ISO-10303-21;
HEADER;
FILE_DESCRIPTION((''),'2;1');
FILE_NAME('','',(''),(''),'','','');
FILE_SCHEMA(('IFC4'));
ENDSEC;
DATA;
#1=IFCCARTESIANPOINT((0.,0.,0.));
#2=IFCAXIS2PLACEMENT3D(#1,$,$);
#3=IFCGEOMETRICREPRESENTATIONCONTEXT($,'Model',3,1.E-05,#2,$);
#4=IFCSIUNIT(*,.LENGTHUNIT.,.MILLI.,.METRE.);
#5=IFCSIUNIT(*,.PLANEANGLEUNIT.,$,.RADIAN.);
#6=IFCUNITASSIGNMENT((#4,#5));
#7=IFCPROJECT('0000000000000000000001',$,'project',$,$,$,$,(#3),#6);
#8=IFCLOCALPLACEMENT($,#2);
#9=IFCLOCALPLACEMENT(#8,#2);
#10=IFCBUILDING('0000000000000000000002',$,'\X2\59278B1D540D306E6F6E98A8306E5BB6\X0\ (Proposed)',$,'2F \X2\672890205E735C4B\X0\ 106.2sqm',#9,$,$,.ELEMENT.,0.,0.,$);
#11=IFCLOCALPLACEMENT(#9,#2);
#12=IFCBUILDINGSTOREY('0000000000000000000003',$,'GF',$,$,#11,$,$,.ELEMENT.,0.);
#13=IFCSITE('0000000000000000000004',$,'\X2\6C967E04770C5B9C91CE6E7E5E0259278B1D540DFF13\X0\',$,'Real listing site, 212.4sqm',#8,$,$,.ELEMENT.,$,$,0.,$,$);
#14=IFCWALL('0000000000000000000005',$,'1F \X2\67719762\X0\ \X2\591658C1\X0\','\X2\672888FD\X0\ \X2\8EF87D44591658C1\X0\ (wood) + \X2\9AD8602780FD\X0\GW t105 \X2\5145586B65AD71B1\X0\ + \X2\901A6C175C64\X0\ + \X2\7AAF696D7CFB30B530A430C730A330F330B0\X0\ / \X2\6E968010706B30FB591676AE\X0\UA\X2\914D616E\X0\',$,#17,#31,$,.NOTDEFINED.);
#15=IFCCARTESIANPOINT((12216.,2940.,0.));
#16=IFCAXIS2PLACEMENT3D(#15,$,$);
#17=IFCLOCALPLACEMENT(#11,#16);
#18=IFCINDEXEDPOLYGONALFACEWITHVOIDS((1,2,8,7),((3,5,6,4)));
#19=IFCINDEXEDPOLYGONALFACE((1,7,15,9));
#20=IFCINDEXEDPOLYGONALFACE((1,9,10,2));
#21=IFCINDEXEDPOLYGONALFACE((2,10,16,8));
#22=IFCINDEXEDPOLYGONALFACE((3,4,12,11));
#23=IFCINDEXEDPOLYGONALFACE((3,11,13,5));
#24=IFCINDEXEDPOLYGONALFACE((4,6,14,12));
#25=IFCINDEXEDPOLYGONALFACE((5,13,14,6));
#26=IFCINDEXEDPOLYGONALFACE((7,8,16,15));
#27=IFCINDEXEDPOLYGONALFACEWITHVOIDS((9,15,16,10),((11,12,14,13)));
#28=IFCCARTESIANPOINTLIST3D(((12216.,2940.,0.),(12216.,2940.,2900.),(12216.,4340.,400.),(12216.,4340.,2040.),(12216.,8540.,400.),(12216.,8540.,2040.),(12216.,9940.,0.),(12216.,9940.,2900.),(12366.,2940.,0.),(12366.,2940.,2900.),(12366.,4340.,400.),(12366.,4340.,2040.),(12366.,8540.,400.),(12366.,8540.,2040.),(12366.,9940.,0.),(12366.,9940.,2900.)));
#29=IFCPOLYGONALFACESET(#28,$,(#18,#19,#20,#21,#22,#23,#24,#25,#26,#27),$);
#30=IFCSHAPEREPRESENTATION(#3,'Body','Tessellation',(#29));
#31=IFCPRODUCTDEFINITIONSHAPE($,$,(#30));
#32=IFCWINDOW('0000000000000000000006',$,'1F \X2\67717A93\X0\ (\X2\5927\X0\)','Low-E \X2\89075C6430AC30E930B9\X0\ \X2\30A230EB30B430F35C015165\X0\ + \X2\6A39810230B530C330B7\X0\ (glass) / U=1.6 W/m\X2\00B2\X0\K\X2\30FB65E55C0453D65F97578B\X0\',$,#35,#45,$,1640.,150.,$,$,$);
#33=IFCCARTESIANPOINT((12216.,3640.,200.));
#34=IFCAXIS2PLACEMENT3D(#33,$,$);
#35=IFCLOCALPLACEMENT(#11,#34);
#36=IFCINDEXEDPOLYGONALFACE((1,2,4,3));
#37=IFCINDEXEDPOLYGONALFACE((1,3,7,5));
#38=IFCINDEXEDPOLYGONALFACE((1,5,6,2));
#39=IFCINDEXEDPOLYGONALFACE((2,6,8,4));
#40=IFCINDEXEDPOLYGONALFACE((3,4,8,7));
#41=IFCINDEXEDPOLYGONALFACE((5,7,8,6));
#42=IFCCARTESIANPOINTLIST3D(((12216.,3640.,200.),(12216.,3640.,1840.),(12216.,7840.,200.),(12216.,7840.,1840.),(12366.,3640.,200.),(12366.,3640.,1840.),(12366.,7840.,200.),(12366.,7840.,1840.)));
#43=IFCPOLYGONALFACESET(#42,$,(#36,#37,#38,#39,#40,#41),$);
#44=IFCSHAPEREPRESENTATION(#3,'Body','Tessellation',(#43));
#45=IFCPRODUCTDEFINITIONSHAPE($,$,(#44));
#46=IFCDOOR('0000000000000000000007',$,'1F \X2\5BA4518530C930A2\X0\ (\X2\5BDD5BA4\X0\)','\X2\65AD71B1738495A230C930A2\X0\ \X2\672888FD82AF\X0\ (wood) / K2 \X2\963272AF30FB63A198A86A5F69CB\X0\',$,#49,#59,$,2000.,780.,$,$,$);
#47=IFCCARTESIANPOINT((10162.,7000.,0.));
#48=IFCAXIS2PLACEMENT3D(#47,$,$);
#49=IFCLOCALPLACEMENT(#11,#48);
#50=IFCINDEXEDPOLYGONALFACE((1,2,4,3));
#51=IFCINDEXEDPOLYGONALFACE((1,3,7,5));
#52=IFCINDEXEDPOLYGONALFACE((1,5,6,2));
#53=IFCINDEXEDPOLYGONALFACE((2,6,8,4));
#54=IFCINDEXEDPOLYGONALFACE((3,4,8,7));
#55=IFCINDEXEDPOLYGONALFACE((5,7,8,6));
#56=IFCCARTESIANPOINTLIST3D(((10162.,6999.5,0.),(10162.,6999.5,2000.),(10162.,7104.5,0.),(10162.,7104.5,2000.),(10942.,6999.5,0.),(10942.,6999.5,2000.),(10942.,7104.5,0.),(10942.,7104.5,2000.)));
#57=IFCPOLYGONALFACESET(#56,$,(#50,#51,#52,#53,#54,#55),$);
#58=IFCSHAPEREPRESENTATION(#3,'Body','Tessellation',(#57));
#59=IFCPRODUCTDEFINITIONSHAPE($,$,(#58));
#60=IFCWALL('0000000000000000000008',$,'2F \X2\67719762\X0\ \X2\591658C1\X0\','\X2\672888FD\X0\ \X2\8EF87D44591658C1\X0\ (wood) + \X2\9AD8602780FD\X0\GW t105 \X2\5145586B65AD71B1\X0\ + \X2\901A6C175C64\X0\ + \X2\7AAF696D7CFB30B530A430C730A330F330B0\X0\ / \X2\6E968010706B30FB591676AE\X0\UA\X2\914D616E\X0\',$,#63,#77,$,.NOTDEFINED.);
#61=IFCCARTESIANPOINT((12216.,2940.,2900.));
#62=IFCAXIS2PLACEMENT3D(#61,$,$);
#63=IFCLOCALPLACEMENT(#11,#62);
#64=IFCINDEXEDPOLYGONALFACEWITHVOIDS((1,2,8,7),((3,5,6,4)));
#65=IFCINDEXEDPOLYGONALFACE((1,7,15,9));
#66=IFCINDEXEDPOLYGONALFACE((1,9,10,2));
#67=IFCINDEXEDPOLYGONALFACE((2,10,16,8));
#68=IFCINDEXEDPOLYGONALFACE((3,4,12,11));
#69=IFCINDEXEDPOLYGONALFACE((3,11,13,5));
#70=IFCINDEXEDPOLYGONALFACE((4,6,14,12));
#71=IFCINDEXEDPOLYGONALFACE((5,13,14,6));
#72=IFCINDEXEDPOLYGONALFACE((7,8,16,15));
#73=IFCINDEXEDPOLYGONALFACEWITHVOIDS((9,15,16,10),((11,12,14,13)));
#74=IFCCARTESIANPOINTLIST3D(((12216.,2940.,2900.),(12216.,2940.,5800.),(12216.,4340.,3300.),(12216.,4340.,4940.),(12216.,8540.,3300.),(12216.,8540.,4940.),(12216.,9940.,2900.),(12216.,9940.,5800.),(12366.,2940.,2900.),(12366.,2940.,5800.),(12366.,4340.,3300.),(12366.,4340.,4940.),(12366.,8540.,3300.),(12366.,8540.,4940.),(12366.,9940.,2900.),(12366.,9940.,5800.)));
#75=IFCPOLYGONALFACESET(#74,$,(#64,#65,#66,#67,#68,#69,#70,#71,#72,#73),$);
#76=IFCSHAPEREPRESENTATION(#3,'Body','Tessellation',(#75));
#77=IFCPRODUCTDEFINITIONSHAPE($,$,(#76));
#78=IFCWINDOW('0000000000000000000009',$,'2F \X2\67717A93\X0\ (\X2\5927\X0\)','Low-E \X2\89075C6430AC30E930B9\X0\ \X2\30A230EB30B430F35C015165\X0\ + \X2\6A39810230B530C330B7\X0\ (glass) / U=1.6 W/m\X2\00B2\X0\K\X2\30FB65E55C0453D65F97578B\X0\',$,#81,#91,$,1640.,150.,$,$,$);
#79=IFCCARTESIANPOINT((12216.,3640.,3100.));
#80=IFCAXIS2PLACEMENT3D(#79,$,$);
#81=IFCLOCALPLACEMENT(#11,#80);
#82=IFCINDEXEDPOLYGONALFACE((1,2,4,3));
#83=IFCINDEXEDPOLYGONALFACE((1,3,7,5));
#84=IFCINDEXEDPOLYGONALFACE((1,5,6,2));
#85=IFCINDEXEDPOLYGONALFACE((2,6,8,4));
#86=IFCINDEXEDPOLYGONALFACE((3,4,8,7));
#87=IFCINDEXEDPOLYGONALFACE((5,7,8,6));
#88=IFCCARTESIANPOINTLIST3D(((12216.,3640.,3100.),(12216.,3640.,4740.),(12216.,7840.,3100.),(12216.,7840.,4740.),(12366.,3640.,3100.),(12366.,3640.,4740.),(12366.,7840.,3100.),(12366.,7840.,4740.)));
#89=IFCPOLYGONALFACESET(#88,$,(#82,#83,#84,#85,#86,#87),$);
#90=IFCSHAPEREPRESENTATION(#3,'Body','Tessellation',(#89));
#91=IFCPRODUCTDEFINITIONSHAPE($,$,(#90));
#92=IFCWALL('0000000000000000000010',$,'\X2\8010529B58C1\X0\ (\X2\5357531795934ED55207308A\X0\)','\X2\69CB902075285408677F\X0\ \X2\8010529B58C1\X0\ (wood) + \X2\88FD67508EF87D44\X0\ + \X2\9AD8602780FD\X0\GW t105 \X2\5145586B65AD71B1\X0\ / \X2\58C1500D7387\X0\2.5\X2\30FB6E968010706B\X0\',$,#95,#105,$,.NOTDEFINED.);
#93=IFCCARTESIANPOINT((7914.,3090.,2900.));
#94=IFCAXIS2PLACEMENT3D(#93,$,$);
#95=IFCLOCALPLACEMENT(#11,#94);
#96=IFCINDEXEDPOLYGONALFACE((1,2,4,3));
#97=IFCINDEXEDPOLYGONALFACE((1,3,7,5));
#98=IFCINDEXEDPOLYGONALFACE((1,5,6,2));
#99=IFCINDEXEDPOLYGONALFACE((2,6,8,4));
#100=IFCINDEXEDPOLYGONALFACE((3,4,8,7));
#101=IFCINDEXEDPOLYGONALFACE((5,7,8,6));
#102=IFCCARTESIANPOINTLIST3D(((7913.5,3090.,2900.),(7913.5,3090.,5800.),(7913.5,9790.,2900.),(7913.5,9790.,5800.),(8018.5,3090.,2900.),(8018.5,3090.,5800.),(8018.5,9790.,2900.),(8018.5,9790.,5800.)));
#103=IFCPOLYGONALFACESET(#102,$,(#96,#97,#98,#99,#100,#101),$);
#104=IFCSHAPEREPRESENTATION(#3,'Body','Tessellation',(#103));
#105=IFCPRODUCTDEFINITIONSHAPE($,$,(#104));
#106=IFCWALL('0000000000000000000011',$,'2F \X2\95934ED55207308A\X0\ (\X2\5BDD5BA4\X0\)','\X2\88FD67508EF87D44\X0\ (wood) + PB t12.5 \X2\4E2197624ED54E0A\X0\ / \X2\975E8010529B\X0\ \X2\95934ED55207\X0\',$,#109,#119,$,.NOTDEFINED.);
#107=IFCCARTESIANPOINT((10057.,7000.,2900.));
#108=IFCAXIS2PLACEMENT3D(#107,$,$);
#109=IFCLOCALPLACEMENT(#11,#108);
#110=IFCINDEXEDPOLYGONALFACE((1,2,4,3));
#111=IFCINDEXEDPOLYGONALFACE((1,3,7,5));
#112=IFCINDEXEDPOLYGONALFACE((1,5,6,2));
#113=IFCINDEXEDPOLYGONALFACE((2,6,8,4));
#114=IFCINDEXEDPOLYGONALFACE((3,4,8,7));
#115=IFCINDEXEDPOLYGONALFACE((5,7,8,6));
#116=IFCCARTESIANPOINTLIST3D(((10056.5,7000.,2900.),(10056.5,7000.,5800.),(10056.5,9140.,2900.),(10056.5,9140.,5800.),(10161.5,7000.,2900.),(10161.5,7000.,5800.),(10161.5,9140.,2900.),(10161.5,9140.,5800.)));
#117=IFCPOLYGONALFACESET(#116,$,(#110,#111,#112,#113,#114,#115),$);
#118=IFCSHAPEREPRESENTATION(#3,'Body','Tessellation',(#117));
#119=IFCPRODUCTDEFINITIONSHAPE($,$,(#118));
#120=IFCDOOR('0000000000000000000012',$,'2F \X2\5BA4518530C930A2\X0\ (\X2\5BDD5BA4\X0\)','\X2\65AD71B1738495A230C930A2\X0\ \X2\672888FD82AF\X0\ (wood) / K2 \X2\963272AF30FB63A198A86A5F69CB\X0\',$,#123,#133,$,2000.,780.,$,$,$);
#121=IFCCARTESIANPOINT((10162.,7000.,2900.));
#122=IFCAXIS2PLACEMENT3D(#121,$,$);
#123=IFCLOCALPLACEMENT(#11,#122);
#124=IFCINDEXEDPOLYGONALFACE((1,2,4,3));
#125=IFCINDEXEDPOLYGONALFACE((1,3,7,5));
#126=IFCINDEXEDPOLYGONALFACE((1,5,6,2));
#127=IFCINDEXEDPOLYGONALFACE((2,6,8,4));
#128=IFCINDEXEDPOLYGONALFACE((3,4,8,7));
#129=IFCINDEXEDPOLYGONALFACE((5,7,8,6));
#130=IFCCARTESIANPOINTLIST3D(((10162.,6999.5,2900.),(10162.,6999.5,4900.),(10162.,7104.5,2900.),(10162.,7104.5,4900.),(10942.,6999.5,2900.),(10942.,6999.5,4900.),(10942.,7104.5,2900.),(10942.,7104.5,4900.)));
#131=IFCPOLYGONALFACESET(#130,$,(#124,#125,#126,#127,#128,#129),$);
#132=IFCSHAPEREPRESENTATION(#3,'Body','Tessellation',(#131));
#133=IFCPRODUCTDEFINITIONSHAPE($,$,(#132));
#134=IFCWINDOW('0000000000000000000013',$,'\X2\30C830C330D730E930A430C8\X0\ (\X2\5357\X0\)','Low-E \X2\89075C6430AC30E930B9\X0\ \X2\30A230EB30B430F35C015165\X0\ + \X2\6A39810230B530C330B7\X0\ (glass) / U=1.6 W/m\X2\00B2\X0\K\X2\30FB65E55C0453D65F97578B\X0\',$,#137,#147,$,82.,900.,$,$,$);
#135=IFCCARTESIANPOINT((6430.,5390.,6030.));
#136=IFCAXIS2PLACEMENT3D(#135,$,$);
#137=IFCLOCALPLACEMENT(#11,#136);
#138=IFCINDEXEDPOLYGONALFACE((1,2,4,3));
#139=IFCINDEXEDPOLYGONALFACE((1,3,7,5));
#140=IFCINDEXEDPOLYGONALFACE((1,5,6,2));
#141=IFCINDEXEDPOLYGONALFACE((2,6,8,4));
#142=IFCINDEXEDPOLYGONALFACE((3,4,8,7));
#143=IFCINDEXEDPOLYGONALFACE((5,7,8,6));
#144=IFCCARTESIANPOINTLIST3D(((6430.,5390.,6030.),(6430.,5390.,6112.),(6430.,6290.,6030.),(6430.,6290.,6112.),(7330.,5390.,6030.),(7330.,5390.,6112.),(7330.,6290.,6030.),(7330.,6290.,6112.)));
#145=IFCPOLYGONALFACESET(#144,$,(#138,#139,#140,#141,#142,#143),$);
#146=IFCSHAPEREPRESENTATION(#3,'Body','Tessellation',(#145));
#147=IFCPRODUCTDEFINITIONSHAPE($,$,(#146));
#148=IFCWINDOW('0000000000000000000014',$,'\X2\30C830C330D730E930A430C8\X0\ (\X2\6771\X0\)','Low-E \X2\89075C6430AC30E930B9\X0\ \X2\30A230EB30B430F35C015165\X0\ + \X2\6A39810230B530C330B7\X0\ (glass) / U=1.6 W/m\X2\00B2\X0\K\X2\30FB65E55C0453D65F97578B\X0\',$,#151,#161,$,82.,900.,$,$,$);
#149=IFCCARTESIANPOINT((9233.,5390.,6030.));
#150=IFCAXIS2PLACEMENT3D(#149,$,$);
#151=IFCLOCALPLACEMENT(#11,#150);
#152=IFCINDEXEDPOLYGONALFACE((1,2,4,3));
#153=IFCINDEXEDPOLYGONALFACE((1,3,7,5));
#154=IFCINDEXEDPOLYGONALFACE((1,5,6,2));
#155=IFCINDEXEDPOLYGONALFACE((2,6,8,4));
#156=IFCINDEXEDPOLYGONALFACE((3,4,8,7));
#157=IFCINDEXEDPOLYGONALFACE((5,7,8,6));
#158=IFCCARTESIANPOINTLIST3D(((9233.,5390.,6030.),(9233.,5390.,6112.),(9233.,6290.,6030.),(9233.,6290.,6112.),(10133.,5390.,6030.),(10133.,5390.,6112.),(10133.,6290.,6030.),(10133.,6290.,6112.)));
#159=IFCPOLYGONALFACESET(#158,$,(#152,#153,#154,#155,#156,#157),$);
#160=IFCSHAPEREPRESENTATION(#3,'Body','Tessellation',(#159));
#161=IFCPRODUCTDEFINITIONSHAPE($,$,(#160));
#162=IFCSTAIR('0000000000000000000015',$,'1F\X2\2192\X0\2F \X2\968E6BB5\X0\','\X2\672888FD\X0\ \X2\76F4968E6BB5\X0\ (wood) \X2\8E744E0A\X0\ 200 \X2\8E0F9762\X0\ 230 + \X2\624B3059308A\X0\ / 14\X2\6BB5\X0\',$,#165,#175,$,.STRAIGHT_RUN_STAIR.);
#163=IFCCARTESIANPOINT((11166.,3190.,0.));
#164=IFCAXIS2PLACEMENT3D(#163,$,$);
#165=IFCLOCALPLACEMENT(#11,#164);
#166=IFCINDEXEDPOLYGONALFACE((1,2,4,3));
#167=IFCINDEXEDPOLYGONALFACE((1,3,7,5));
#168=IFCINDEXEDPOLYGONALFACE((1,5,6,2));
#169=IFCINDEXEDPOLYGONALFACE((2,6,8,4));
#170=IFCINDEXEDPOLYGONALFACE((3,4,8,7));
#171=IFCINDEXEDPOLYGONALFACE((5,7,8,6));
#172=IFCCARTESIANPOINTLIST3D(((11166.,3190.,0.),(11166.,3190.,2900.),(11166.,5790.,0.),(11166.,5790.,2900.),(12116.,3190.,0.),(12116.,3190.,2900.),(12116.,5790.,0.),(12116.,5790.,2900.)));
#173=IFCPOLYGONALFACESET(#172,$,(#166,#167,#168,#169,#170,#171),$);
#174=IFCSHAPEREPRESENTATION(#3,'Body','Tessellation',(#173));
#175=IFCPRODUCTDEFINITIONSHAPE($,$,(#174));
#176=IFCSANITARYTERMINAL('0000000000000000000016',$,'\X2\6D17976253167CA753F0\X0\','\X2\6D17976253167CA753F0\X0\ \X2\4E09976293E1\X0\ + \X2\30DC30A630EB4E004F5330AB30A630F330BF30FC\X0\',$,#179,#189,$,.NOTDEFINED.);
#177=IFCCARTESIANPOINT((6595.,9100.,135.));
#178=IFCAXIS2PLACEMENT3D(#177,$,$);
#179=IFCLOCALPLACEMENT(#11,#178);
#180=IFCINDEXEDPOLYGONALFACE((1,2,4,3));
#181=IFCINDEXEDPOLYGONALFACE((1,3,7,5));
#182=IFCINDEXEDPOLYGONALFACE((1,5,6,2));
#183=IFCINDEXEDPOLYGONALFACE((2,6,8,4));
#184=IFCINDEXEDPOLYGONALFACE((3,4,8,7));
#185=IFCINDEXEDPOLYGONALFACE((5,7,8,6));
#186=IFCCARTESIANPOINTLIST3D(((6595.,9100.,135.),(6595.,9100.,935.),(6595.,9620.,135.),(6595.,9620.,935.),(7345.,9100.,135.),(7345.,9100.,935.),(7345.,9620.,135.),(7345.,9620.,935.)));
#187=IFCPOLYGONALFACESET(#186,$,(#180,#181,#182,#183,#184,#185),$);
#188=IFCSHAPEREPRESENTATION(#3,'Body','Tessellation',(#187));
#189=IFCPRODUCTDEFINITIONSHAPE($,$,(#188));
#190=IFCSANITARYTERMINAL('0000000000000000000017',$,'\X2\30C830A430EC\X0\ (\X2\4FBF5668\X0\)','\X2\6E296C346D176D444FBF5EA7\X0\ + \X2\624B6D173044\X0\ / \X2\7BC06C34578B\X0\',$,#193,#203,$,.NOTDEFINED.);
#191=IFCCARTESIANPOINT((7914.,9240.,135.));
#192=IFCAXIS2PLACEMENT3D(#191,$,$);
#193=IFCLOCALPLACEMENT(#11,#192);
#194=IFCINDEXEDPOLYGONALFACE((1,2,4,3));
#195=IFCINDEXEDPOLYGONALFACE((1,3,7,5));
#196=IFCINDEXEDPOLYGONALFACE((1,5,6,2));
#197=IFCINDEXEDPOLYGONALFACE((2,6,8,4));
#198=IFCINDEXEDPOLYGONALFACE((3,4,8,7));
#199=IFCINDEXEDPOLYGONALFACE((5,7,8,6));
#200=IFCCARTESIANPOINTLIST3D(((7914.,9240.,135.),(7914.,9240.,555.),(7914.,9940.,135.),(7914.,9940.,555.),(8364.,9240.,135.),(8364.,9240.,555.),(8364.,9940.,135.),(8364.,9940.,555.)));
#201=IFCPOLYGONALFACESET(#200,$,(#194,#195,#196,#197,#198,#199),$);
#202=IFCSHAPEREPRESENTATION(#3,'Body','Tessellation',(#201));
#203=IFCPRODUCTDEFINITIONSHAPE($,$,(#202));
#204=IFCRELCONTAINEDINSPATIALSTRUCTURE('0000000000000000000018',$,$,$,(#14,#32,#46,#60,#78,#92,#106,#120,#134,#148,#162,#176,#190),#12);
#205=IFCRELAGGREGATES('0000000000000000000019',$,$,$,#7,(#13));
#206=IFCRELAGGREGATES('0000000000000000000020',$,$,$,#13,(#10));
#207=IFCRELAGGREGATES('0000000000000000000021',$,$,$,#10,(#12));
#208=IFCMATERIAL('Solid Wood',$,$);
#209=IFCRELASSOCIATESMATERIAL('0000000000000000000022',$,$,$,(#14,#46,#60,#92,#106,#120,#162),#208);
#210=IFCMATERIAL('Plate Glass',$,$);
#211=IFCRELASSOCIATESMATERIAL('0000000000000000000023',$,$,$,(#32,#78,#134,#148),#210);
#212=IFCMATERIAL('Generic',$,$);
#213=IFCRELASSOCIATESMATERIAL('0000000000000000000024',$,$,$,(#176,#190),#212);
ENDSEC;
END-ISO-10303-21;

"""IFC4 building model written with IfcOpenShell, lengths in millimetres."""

from ifc_helpers import new_model, si_unit, frame, frame_2d, origin, place, context, project, spatial, rectangle, extrude, material, element, fill, save


model = new_model("IFC4")

# Units and contexts
model_context = context("Model", 3, precision=1e-05, world=origin())
ifc_project = project(units=[si_unit("LENGTHUNIT", "METRE", prefix="MILLI"), si_unit("PLANEANGLEUNIT", "RADIAN")], contexts=[model_context])

# Site, building, storey
site_placement = place(None, origin())
site = spatial("IfcSite", under=ifc_project, at=site_placement, Name="沖縄県宜野湾市大謝名３", ObjectType="Real listing site, 212.4sqm", CompositionType="ELEMENT", RefElevation=0.0)
building_placement = place(site_placement, origin())
building = spatial("IfcBuilding", under=site, at=building_placement, Name="大謝名の潮風の家 (Proposed)", ObjectType="2F 木造平屋 106.2sqm", CompositionType="ELEMENT", ElevationOfRefHeight=0.0, ElevationOfTerrain=0.0)
storey_placement = place(building_placement, origin())
storey = spatial("IfcBuildingStorey", under=building, at=storey_placement, Name="GF", CompositionType="ELEMENT", Elevation=0.0)

# Wall, opening, window
ifc_material_1 = material(Name="Solid Wood")
wall_1_placement = place(storey_placement, frame((12216.0, 2940.0, 0.0)))
wall_1 = element("IfcWall", 1, at=wall_1_placement, inside=storey, material=ifc_material_1, Name="1F 東面 外壁", Description="木製 軸組外壁 (wood) + 高性能GW t105 充填断熱 + 通気層 + 窯業系サイディング / 準耐火・外皮UA配慮", PredefinedType="NOTDEFINED", context=model_context, shape_type="SweptSolid", body=[
    extrude(rectangle(XDim=150.0, YDim=7000.0, at=frame_2d((75.0, 3500.0))), frame((12216.0, 2940.0, 0.0)), (0.0, 0.0, 1.0), 2900.0),
])
opening_1_placement = place(storey_placement, frame((12216.0, 3640.0, 200.0)))
opening_1 = element("IfcOpeningElement", 2, at=opening_1_placement, cuts=wall_1, PredefinedType="NOTDEFINED", context=model_context, shape_type="SweptSolid", body=[
    extrude(rectangle(XDim=150.0, YDim=4200.0, at=frame_2d((75.0, 2100.0))), frame((12216.0, 3640.0, 200.0)), (0.0, 0.0, 1.0), 1640.0),
])
ifc_material_2 = material(Name="Plate Glass")
window_1_placement = place(storey_placement, frame((12216.0, 3640.0, 200.0)))
window_1 = element("IfcWindow", 3, at=window_1_placement, inside=storey, material=ifc_material_2, Name="1F 東窓 (大)", Description="Low-E 複層ガラス アルゴン封入 + 樹脂サッシ (glass) / U=1.6 W/m²K・日射取得型", OverallHeight=1640.0, OverallWidth=150.0, context=model_context, shape_type="SweptSolid", body=[
    extrude(rectangle(XDim=150.0, YDim=4200.0, at=frame_2d((75.0, 2100.0))), frame((12216.0, 3640.0, 200.0)), (0.0, 0.0, 1.0), 1640.0),
])
fill(opening_1, window_1)

# Door
door_1_placement = place(storey_placement, frame((10162.0, 7000.0, 0.0)))
element("IfcDoor", 4, at=door_1_placement, inside=storey, material=ifc_material_1, Name="1F 室内ドア (寝室)", Description="断熱玄関ドア 木製芯 (wood) / K2 防犯・採風機構", OverallHeight=2000.0, OverallWidth=780.0, context=model_context, shape_type="SweptSolid", body=[
    extrude(rectangle(XDim=780.0, YDim=105.0, at=frame_2d((390.0, 52.0))), frame((10162.0, 7000.0, 0.0)), (0.0, 0.0, 1.0), 2000.0),
])

# Wall, opening, window
wall_2_placement = place(storey_placement, frame((12216.0, 2940.0, 2900.0)))
wall_2 = element("IfcWall", 5, at=wall_2_placement, inside=storey, material=ifc_material_1, Name="2F 東面 外壁", Description="木製 軸組外壁 (wood) + 高性能GW t105 充填断熱 + 通気層 + 窯業系サイディング / 準耐火・外皮UA配慮", PredefinedType="NOTDEFINED", context=model_context, shape_type="SweptSolid", body=[
    extrude(rectangle(XDim=150.0, YDim=7000.0, at=frame_2d((75.0, 3500.0))), frame((12216.0, 2940.0, 2900.0)), (0.0, 0.0, 1.0), 2900.0),
])
opening_2_placement = place(storey_placement, frame((12216.0, 3640.0, 3100.0)))
opening_2 = element("IfcOpeningElement", 6, at=opening_2_placement, cuts=wall_2, PredefinedType="NOTDEFINED", context=model_context, shape_type="SweptSolid", body=[
    extrude(rectangle(XDim=150.0, YDim=4200.0, at=frame_2d((75.0, 2100.0))), frame((12216.0, 3640.0, 3100.0)), (0.0, 0.0, 1.0), 1640.0),
])
window_2_placement = place(storey_placement, frame((12216.0, 3640.0, 3100.0)))
window_2 = element("IfcWindow", 7, at=window_2_placement, inside=storey, material=ifc_material_2, Name="2F 東窓 (大)", Description="Low-E 複層ガラス アルゴン封入 + 樹脂サッシ (glass) / U=1.6 W/m²K・日射取得型", OverallHeight=1640.0, OverallWidth=150.0, context=model_context, shape_type="SweptSolid", body=[
    extrude(rectangle(XDim=150.0, YDim=4200.0, at=frame_2d((75.0, 2100.0))), frame((12216.0, 3640.0, 3100.0)), (0.0, 0.0, 1.0), 1640.0),
])
fill(opening_2, window_2)

# Walls
wall_3_placement = place(storey_placement, frame((7914.0, 3090.0, 2900.0)))
element("IfcWall", 8, at=wall_3_placement, inside=storey, material=ifc_material_1, Name="耐力壁 (南北間仕切り)", Description="構造用合板 耐力壁 (wood) + 製材軸組 + 高性能GW t105 充填断熱 / 壁倍率2.5・準耐火", PredefinedType="NOTDEFINED", context=model_context, shape_type="SweptSolid", body=[
    extrude(rectangle(XDim=105.0, YDim=6700.0, at=frame_2d((52.0, 3350.0))), frame((7914.0, 3090.0, 2900.0)), (0.0, 0.0, 1.0), 2900.0),
])
wall_4_placement = place(storey_placement, frame((10057.0, 7000.0, 2900.0)))
element("IfcWall", 9, at=wall_4_placement, inside=storey, material=ifc_material_1, Name="2F 間仕切り (寝室)", Description="製材軸組 (wood) + PB t12.5 両面仕上 / 非耐力 間仕切", PredefinedType="NOTDEFINED", context=model_context, shape_type="SweptSolid", body=[
    extrude(rectangle(XDim=105.0, YDim=2140.0, at=frame_2d((52.0, 1070.0))), frame((10057.0, 7000.0, 2900.0)), (0.0, 0.0, 1.0), 2900.0),
])

# Door
door_2_placement = place(storey_placement, frame((10162.0, 7000.0, 2900.0)))
element("IfcDoor", 10, at=door_2_placement, inside=storey, material=ifc_material_1, Name="2F 室内ドア (寝室)", Description="断熱玄関ドア 木製芯 (wood) / K2 防犯・採風機構", OverallHeight=2000.0, OverallWidth=780.0, context=model_context, shape_type="SweptSolid", body=[
    extrude(rectangle(XDim=780.0, YDim=105.0, at=frame_2d((390.0, 52.0))), frame((10162.0, 7000.0, 2900.0)), (0.0, 0.0, 1.0), 2000.0),
])

# Windows
window_3_placement = place(storey_placement, frame((6430.0, 5390.0, 6030.0)))
element("IfcWindow", 11, at=window_3_placement, inside=storey, material=ifc_material_2, Name="トップライト (南)", Description="Low-E 複層ガラス アルゴン封入 + 樹脂サッシ (glass) / U=1.6 W/m²K・日射取得型", OverallHeight=82.0, OverallWidth=900.0, context=model_context, shape_type="SweptSolid", body=[
    extrude(rectangle(XDim=900.0, YDim=900.0, at=frame_2d((450.0, 450.0))), frame((6430.0, 5390.0, 6030.0)), (0.0, 0.0, 1.0), 82.0),
])
window_4_placement = place(storey_placement, frame((9233.0, 5390.0, 6030.0)))
element("IfcWindow", 12, at=window_4_placement, inside=storey, material=ifc_material_2, Name="トップライト (東)", Description="Low-E 複層ガラス アルゴン封入 + 樹脂サッシ (glass) / U=1.6 W/m²K・日射取得型", OverallHeight=82.0, OverallWidth=900.0, context=model_context, shape_type="SweptSolid", body=[
    extrude(rectangle(XDim=900.0, YDim=900.0, at=frame_2d((450.0, 450.0))), frame((9233.0, 5390.0, 6030.0)), (0.0, 0.0, 1.0), 82.0),
])

# Stair
stair_placement = place(storey_placement, frame((11166.0, 3190.0, 0.0)))
element("IfcStair", 13, at=stair_placement, inside=storey, material=ifc_material_1, Name="1F→2F 階段", Description="木製 直階段 (wood) 蹴上 200 踏面 230 + 手すり / 14段", PredefinedType="STRAIGHT_RUN_STAIR", context=model_context, shape_type="SweptSolid", body=[
    extrude(rectangle(XDim=950.0, YDim=2600.0, at=frame_2d((475.0, 1300.0))), frame((11166.0, 3190.0, 0.0)), (0.0, 0.0, 1.0), 2900.0),
])

# Sanitary terminals
ifc_material_3 = material(Name="Generic")
sanitary_terminal_1_placement = place(storey_placement, frame((6595.0, 9100.0, 135.0)))
element("IfcSanitaryTerminal", 14, at=sanitary_terminal_1_placement, inside=storey, material=ifc_material_3, Name="洗面化粧台", Description="洗面化粧台 三面鏡 + ボウル一体カウンター", PredefinedType="NOTDEFINED", context=model_context, shape_type="SweptSolid", body=[
    extrude(rectangle(XDim=750.0, YDim=520.0, at=frame_2d((375.0, 260.0))), frame((6595.0, 9100.0, 135.0)), (0.0, 0.0, 1.0), 800.0),
])
sanitary_terminal_2_placement = place(storey_placement, frame((7914.0, 9240.0, 135.0)))
element("IfcSanitaryTerminal", 15, at=sanitary_terminal_2_placement, inside=storey, material=ifc_material_3, Name="トイレ (便器)", Description="温水洗浄便座 + 手洗い / 節水型", PredefinedType="NOTDEFINED", context=model_context, shape_type="SweptSolid", body=[
    extrude(rectangle(XDim=450.0, YDim=700.0, at=frame_2d((225.0, 350.0))), frame((7914.0, 9240.0, 135.0)), (0.0, 0.0, 1.0), 420.0),
])

save(model, "model.ifc")
